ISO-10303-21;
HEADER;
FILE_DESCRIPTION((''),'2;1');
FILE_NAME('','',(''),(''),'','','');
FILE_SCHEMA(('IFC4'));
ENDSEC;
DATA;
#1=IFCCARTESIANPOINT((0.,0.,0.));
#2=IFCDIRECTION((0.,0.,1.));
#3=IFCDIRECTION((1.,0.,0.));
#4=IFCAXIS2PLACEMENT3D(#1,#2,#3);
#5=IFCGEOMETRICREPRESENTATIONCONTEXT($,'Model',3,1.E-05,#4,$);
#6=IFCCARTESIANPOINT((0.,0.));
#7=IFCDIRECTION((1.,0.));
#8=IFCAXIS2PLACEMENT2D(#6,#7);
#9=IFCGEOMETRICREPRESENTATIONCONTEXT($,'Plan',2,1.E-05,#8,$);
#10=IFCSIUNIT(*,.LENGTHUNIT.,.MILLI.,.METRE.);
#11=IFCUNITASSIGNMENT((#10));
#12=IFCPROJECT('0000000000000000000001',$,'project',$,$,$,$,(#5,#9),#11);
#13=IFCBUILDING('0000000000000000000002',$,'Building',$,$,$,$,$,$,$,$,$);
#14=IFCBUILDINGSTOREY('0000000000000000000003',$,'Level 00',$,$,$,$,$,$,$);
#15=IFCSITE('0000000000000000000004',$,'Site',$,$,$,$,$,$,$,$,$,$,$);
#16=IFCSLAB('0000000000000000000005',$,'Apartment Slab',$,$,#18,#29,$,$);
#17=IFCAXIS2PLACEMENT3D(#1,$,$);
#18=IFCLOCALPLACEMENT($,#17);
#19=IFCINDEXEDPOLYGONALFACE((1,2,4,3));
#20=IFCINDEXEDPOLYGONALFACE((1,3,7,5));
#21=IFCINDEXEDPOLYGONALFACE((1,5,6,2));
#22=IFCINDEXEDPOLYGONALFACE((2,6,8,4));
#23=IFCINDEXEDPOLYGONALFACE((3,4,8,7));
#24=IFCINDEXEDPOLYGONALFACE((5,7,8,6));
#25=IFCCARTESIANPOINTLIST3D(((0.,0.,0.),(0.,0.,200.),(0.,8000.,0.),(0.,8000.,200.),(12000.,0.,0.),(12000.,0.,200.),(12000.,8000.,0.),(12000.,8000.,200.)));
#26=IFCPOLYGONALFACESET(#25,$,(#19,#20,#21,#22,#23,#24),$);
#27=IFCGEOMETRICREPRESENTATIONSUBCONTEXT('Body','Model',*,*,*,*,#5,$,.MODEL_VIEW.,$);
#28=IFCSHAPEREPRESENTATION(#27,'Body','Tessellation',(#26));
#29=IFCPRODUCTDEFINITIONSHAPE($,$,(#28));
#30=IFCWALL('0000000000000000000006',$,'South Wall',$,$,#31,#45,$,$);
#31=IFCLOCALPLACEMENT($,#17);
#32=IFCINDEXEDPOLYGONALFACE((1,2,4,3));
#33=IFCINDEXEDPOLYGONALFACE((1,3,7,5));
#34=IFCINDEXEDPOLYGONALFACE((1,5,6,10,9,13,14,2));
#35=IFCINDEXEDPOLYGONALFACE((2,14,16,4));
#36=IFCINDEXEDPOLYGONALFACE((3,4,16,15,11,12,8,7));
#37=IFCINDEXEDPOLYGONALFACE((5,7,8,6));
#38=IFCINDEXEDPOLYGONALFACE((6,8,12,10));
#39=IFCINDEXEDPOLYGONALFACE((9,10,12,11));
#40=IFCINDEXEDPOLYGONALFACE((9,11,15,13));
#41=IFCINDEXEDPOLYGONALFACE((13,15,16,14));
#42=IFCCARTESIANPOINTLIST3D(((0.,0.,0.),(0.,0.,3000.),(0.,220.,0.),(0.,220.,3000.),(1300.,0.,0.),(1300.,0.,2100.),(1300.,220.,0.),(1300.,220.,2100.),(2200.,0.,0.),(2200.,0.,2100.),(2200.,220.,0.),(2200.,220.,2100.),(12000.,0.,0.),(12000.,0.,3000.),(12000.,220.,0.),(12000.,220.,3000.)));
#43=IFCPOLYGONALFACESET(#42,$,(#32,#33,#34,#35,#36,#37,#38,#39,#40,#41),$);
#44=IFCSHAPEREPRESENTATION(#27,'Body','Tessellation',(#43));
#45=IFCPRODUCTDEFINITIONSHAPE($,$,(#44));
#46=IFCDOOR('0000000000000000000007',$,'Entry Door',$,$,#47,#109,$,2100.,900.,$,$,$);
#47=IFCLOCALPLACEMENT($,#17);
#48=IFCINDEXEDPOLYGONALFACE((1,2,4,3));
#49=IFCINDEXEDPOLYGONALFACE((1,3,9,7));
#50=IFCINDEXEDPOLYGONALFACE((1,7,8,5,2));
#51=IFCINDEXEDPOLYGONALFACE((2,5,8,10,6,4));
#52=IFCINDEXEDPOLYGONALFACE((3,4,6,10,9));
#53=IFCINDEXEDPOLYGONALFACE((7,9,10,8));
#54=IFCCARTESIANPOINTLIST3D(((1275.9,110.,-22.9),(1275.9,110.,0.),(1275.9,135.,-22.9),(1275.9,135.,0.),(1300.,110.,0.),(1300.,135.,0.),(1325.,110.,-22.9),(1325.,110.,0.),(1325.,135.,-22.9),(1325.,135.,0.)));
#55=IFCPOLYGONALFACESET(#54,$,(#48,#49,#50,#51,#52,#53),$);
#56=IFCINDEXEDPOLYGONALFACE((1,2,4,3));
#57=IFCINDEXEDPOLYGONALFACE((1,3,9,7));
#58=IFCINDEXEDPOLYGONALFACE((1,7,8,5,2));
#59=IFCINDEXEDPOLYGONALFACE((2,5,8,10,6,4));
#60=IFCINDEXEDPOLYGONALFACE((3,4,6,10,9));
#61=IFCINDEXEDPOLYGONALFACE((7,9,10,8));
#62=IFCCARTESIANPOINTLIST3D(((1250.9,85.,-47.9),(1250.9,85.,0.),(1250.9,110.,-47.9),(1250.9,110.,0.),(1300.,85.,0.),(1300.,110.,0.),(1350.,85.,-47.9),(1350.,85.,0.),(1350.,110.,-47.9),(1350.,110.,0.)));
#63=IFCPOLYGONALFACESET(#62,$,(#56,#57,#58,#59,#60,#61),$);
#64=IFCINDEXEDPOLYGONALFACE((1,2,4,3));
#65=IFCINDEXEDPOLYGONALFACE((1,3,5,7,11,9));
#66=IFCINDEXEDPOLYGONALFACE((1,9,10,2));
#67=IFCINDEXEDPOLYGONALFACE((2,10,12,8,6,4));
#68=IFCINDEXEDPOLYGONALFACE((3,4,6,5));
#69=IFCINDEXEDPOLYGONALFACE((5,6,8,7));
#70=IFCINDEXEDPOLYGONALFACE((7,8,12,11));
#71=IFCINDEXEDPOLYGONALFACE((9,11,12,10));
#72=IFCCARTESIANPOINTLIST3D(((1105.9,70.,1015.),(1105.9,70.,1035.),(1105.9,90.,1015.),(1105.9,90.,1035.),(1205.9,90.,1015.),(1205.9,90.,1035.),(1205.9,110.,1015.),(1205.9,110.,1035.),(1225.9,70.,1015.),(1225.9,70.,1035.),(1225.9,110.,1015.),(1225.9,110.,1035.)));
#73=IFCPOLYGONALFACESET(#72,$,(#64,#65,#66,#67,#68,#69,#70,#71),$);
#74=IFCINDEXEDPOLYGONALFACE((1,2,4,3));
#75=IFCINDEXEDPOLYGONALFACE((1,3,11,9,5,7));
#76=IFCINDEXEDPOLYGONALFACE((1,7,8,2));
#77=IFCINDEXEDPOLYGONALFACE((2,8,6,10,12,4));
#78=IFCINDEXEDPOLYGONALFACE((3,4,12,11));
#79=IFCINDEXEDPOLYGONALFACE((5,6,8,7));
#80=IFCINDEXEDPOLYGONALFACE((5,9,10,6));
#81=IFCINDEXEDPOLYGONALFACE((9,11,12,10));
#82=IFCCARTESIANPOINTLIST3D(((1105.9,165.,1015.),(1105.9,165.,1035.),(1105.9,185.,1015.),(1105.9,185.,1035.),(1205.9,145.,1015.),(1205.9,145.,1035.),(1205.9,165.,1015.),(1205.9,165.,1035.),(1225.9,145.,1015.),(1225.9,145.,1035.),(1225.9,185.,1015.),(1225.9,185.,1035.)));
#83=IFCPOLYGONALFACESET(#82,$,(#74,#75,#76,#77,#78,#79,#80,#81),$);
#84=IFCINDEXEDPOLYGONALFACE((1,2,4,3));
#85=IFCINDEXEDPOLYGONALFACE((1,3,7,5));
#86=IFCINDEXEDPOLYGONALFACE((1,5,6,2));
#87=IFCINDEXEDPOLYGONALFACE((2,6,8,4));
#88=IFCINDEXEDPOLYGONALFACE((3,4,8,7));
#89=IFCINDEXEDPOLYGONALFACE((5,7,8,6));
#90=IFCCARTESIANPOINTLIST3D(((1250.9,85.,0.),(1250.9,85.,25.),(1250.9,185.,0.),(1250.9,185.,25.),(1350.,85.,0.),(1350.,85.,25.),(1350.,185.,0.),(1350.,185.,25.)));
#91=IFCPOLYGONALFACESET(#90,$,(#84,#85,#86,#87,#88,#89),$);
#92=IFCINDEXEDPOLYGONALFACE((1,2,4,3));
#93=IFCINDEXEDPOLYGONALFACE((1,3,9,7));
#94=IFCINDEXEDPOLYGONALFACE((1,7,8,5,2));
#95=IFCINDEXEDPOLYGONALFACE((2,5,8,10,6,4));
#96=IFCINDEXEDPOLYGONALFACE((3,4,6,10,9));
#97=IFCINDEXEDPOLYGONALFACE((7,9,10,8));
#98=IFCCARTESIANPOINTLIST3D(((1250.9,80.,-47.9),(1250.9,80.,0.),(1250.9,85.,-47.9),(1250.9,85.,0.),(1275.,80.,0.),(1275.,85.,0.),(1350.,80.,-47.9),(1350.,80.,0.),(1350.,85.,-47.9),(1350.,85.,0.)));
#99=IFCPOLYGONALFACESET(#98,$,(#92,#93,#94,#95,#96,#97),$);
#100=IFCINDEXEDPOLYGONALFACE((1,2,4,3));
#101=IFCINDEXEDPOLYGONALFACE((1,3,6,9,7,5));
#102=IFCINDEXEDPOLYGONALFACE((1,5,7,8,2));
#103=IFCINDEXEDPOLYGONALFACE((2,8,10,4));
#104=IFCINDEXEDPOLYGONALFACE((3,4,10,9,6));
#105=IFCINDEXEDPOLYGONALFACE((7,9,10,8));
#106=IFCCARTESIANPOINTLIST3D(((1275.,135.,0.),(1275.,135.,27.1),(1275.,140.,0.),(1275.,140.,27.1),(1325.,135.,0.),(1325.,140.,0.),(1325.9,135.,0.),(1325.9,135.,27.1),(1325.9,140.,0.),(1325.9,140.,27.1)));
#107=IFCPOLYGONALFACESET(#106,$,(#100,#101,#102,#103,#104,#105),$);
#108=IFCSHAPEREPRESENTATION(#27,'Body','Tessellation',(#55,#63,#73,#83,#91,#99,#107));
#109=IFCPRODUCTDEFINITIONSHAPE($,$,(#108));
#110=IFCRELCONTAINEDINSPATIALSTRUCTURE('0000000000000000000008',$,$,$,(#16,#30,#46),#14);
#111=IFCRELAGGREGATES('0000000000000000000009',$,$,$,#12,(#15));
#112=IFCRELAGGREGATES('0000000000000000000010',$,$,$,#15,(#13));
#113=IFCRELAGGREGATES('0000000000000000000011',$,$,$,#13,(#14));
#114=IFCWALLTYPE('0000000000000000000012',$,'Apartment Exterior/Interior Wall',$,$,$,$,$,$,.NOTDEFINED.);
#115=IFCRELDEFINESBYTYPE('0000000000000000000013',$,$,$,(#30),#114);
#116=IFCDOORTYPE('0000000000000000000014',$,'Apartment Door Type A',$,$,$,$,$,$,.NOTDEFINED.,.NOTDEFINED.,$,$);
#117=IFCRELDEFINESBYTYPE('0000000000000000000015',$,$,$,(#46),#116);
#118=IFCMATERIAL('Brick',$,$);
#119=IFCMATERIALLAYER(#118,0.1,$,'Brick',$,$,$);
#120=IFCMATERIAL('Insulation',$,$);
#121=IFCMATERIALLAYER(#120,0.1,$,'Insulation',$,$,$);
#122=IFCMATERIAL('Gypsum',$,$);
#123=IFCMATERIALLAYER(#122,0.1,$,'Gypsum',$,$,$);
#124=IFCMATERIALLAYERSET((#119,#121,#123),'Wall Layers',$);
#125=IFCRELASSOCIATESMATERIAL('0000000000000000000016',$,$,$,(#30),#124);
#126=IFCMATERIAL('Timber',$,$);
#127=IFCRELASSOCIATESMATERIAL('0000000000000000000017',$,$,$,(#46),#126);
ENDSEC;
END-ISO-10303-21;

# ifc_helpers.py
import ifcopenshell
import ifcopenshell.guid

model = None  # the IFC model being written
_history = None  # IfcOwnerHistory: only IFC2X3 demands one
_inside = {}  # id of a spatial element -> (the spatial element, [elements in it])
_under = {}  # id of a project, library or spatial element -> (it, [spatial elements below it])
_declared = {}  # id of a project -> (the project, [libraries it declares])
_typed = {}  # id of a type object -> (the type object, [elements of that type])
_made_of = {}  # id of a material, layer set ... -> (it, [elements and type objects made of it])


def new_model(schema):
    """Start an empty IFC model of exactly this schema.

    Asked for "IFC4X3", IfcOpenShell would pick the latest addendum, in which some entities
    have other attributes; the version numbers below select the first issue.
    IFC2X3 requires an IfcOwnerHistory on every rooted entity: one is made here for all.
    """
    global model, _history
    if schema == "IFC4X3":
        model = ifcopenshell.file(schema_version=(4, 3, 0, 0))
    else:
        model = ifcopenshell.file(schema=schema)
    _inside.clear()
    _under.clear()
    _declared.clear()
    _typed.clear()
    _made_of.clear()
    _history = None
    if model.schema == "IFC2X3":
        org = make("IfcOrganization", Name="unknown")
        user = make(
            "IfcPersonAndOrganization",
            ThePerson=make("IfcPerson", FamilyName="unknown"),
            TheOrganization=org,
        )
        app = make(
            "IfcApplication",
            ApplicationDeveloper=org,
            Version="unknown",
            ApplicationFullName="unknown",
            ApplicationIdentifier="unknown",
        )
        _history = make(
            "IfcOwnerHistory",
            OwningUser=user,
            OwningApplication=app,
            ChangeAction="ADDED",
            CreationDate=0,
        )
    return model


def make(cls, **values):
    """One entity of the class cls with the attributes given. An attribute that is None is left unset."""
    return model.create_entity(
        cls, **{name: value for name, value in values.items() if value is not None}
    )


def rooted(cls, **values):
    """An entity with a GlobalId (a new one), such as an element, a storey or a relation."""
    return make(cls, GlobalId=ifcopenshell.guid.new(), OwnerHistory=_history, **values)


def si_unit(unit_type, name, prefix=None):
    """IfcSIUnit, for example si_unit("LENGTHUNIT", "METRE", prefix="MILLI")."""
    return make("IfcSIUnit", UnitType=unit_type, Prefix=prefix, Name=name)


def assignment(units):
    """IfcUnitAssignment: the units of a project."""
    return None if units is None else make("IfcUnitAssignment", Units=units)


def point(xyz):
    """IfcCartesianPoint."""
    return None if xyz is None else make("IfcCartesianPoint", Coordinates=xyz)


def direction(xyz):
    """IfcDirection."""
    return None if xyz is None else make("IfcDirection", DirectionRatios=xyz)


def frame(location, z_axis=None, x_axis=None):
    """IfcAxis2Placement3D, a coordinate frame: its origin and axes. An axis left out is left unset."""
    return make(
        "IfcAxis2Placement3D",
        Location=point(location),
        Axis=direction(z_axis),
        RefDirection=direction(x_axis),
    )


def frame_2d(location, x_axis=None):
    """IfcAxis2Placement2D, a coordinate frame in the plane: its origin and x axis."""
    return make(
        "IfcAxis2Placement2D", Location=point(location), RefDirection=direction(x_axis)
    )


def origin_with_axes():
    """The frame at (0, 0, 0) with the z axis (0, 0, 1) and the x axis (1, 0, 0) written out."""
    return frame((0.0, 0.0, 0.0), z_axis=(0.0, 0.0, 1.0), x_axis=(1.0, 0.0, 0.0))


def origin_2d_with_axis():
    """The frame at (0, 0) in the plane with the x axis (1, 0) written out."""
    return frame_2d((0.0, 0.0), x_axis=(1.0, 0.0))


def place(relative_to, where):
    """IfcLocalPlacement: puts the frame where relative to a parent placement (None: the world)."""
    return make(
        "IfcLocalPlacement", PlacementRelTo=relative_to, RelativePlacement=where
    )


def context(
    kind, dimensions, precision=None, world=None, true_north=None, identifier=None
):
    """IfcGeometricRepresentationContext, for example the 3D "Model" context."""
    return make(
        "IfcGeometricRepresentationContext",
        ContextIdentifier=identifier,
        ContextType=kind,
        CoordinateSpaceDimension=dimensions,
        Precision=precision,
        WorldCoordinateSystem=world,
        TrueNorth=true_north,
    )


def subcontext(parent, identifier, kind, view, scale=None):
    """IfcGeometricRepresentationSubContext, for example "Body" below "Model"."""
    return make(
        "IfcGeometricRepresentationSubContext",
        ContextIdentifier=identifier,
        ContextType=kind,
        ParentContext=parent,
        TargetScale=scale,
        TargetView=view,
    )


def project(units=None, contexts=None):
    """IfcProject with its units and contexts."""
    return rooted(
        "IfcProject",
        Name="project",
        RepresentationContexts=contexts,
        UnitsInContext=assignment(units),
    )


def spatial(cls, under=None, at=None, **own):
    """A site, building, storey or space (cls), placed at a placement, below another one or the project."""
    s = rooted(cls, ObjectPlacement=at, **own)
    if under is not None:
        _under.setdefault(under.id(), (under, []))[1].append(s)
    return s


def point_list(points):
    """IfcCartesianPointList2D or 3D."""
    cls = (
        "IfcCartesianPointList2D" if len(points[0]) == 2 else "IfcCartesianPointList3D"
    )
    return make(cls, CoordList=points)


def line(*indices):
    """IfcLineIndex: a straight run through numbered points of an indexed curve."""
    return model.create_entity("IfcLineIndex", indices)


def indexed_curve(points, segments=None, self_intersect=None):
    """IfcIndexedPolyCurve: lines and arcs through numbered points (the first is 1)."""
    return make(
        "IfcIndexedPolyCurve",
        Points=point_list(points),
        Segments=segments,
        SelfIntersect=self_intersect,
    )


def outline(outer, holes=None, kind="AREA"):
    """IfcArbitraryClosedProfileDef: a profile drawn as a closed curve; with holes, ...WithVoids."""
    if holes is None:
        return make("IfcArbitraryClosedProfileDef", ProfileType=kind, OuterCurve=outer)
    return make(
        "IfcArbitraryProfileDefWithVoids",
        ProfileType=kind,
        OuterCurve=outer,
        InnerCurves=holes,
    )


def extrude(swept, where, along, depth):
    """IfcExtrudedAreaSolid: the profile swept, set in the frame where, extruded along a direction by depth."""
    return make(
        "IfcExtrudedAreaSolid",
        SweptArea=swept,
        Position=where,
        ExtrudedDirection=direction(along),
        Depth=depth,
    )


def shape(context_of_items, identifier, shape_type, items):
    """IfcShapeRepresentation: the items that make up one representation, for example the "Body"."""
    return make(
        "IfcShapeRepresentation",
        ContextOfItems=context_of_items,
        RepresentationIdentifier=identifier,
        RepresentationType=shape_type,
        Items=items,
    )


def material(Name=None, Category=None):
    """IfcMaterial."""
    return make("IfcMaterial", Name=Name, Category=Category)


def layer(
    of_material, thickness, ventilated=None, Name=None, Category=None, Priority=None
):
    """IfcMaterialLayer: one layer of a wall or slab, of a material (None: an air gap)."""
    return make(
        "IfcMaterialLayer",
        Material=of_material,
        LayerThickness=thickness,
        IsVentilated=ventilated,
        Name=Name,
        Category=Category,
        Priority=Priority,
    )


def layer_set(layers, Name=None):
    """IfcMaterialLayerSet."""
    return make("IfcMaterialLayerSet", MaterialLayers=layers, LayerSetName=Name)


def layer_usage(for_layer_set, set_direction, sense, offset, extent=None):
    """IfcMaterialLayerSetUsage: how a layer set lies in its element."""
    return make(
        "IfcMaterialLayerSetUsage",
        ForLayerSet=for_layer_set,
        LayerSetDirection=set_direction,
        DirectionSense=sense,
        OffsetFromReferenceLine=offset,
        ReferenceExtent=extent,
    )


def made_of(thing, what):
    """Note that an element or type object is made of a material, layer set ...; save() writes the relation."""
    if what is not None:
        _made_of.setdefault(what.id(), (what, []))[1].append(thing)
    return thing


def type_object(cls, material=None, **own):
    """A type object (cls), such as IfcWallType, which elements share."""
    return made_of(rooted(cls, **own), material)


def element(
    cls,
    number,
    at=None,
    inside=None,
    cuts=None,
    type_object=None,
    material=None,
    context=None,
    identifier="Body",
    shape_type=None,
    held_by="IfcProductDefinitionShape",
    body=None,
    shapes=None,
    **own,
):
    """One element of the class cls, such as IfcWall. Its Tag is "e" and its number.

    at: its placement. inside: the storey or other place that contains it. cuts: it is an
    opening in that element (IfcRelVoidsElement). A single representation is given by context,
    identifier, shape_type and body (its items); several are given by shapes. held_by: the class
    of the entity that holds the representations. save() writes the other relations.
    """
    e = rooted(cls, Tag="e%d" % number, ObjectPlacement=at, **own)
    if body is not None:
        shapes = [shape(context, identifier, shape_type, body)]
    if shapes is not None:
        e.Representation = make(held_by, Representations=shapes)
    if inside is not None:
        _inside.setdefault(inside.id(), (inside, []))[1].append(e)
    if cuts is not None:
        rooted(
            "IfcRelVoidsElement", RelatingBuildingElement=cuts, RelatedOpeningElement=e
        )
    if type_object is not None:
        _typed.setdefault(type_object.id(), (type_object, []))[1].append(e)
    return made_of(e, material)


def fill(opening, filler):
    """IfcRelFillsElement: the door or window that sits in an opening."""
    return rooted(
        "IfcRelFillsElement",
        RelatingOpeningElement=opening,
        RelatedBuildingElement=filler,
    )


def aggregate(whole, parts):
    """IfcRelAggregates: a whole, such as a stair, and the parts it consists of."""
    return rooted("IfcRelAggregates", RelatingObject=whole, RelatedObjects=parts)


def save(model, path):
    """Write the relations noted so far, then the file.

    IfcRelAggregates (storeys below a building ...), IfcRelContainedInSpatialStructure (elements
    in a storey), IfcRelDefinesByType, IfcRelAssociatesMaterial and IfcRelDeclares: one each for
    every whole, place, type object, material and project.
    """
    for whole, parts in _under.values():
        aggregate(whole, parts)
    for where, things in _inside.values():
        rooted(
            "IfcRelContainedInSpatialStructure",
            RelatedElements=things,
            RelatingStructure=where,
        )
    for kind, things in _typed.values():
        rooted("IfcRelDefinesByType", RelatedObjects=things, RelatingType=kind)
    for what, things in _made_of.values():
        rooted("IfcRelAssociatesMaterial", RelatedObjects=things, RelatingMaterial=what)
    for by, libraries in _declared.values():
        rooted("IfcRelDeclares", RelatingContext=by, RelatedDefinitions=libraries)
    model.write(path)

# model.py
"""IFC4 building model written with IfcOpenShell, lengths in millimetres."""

from ifc_helpers import new_model, si_unit, frame, origin_with_axes, origin_2d_with_axis, place, context, subcontext, project, spatial, line, indexed_curve, outline, extrude, material, layer, layer_set, layer_usage, type_object, element, fill, save


model = new_model("IFC4")

# Units and contexts
model_context = context("Model", 3, precision=1e-05, world=origin_with_axes())
plan_context = context("Plan", 2, precision=1e-05, world=origin_2d_with_axis())
body_context = subcontext(model_context, "Body", "Model", "MODEL_VIEW")
ifc_project = project(units=[si_unit("LENGTHUNIT", "METRE", prefix="MILLI")], contexts=[model_context, plan_context])

# Site, building, storey
site = spatial("IfcSite", under=ifc_project, Name="Site")
building = spatial("IfcBuilding", under=site, Name="Building")
storey = spatial("IfcBuildingStorey", under=building, Name="Level 00")

# Slab
slab_placement = place(None, origin_with_axes())
element("IfcSlab", 1, at=slab_placement, inside=storey, Name="Apartment Slab", context=body_context, shape_type="SweptSolid", body=[
    extrude(outline(indexed_curve([(0.0, 0.0), (12000.0, 0.0), (12000.0, 8000.0), (0.0, 8000.0), (0.0, 0.0)])), None, (0.0, 0.0, 1.0), 200.0),
])

# Wall, opening, door
ifc_material_1 = material(Name="Brick")
ifc_layer_1 = layer(ifc_material_1, 0.1, Name="Brick")
ifc_material_2 = material(Name="Insulation")
ifc_layer_2 = layer(ifc_material_2, 0.1, Name="Insulation")
ifc_material_3 = material(Name="Gypsum")
ifc_layer_3 = layer(ifc_material_3, 0.1, Name="Gypsum")
ifc_layer_set = layer_set([ifc_layer_1, ifc_layer_2, ifc_layer_3], Name="Wall Layers")
ifc_layer_usage = layer_usage(ifc_layer_set, "AXIS2", "POSITIVE", 0.0)
wall_type = type_object("IfcWallType", Name="Apartment Exterior/Interior Wall", PredefinedType="NOTDEFINED")
wall_1_placement = place(None, origin_with_axes())
wall_1 = element("IfcWall", 2, at=wall_1_placement, inside=storey, type_object=wall_type, material=ifc_layer_usage, Name="South Wall", context=body_context, shape_type="SweptSolid", body=[
    extrude(outline(indexed_curve([(0.0, 0.0), (0.0, 220.0), (12000.0, 220.0), (12000.0, 0.0), (0.0, 0.0)], self_intersect=False)), origin_with_axes(), (0.0, 0.0, 1.0), 3000.0),
])
opening_1_placement = place(wall_1_placement, frame((1300.0, -22.0, 0.0), z_axis=(0.0, 0.0, 1.0), x_axis=(1.0, 0.0, 0.0)))
opening_1 = element("IfcOpeningElement", 3, at=opening_1_placement, cuts=wall_1, context=body_context, shape_type="SweptSolid", body=[
    extrude(outline(indexed_curve([(0.0, 0.0), (0.0, 264.0), (900.0, 264.0), (900.0, 0.0), (0.0, 0.0)], self_intersect=False)), origin_with_axes(), (0.0, 0.0, 1.0), 2100.0),
])
ifc_material_4 = material(Name="Timber")
door_type = type_object("IfcDoorType", Name="Apartment Door Type A", OperationType="NOTDEFINED", PredefinedType="NOTDEFINED")
door_1_placement = place(opening_1_placement, frame((0.0, 107.0, 0.0), z_axis=(0.0, 0.0, 1.0), x_axis=(1.0, 0.0, 0.0)))
door_1 = element("IfcDoor", 4, at=door_1_placement, inside=storey, type_object=door_type, material=ifc_material_4, Name="Entry Door", OverallHeight=2100.0, OverallWidth=900.0, context=body_context, shape_type="SweptSolid", body=[
    extrude(outline(indexed_curve([(0.0, 0.0), (0.0, 2.1), (0.9, 2.1), (0.9, 0.0), (-24.1, 0.0), (-24.1, -22.9), (25.0, -22.9), (25.0, 0.0)], segments=[line(1, 2, 3, 4, 5, 6, 7, 8, 1)])), frame((0.0, 25.0, 0.0), z_axis=(0.0, -1.0, 0.0), x_axis=(1.0, 0.0, 0.0)), (0.0, 0.0, -1.0), 25.0),
    extrude(outline(indexed_curve([(0.0, 0.0), (0.0, 2.1), (0.9, 2.1), (0.9, 0.0), (-49.1, 0.0), (-49.1, -47.9), (50.0, -47.9), (50.0, 0.0)], segments=[line(1, 2, 3, 4, 5, 6, 7, 8, 1)])), frame((0.0, 0.0, 0.0), z_axis=(0.0, -1.0, 0.0), x_axis=(1.0, 0.0, 0.0)), (0.0, 0.0, -1.0), 25.0),
    extrude(outline(indexed_curve([(0.0, 0.0), (-49.1, 0.0), (-49.1, 35.0), (0.0, 35.0)], segments=[line(1, 2, 3, 4, 1)])), frame((25.0, 25.0, 25.0), z_axis=(0.0, 0.0, 1.0), x_axis=(1.0, 0.0, 0.0)), (0.0, 0.0, 1.0), -47.9),
    extrude(outline(indexed_curve([(0.0, 0.0), (0.0, -40.0), (-120.0, -40.0), (-120.0, -20.0), (-20.0, -20.0), (-20.0, 0.0)], segments=[line(1, 2, 3, 4, 5, 6, 1)])), frame((-74.1, 25.0, 1015.0), z_axis=(0.0, 0.0, 1.0), x_axis=(1.0, 0.0, 0.0)), (0.0, 0.0, 1.0), 20.0),
    extrude(outline(indexed_curve([(0.0, 0.0), (0.0, 40.0), (-120.0, 40.0), (-120.0, 20.0), (-20.0, 20.0), (-20.0, 0.0)], segments=[line(1, 2, 3, 4, 5, 6, 1)])), frame((-74.1, 60.0, 1015.0), z_axis=(0.0, 0.0, 1.0), x_axis=(1.0, 0.0, 0.0)), (0.0, 0.0, 1.0), 20.0),
    extrude(outline(indexed_curve([(0.0, 0.0), (-99.1, 0.0), (-99.1, 100.0), (0.0, 100.0)], segments=[line(1, 2, 3, 4, 1)])), frame((50.0, 0.0, 0.0), z_axis=(0.0, 0.0, 1.0), x_axis=(1.0, 0.0, 0.0)), (0.0, 0.0, 1.0), 25.0),
    extrude(outline(indexed_curve([(0.0, 0.0), (0.0, 27.1), (50.9, 27.1), (50.9, 0.0), (-24.1, 0.0), (-24.1, -47.9), (75.0, -47.9), (75.0, 0.0)], segments=[line(1, 2, 3, 4, 5, 6, 7, 8, 1)])), frame((-25.0, -5.0, 0.0), z_axis=(0.0, -1.0, 0.0), x_axis=(1.0, 0.0, 0.0)), (0.0, 0.0, -1.0), 5.0),
    extrude(outline(indexed_curve([(0.0, 0.0), (0.0, 27.1), (50.9, 27.1), (50.9, 0.0), (0.9, 0.0), (0.9, -22.9), (50.0, -22.9), (50.0, 0.0)], segments=[line(1, 2, 3, 4, 5, 6, 7, 8, 1)])), frame((-25.0, 50.0, 0.0), z_axis=(0.0, -1.0, 0.0), x_axis=(1.0, 0.0, 0.0)), (0.0, 0.0, -1.0), 5.0),
])
fill(opening_1, door_1)

save(model, "model.ifc")
